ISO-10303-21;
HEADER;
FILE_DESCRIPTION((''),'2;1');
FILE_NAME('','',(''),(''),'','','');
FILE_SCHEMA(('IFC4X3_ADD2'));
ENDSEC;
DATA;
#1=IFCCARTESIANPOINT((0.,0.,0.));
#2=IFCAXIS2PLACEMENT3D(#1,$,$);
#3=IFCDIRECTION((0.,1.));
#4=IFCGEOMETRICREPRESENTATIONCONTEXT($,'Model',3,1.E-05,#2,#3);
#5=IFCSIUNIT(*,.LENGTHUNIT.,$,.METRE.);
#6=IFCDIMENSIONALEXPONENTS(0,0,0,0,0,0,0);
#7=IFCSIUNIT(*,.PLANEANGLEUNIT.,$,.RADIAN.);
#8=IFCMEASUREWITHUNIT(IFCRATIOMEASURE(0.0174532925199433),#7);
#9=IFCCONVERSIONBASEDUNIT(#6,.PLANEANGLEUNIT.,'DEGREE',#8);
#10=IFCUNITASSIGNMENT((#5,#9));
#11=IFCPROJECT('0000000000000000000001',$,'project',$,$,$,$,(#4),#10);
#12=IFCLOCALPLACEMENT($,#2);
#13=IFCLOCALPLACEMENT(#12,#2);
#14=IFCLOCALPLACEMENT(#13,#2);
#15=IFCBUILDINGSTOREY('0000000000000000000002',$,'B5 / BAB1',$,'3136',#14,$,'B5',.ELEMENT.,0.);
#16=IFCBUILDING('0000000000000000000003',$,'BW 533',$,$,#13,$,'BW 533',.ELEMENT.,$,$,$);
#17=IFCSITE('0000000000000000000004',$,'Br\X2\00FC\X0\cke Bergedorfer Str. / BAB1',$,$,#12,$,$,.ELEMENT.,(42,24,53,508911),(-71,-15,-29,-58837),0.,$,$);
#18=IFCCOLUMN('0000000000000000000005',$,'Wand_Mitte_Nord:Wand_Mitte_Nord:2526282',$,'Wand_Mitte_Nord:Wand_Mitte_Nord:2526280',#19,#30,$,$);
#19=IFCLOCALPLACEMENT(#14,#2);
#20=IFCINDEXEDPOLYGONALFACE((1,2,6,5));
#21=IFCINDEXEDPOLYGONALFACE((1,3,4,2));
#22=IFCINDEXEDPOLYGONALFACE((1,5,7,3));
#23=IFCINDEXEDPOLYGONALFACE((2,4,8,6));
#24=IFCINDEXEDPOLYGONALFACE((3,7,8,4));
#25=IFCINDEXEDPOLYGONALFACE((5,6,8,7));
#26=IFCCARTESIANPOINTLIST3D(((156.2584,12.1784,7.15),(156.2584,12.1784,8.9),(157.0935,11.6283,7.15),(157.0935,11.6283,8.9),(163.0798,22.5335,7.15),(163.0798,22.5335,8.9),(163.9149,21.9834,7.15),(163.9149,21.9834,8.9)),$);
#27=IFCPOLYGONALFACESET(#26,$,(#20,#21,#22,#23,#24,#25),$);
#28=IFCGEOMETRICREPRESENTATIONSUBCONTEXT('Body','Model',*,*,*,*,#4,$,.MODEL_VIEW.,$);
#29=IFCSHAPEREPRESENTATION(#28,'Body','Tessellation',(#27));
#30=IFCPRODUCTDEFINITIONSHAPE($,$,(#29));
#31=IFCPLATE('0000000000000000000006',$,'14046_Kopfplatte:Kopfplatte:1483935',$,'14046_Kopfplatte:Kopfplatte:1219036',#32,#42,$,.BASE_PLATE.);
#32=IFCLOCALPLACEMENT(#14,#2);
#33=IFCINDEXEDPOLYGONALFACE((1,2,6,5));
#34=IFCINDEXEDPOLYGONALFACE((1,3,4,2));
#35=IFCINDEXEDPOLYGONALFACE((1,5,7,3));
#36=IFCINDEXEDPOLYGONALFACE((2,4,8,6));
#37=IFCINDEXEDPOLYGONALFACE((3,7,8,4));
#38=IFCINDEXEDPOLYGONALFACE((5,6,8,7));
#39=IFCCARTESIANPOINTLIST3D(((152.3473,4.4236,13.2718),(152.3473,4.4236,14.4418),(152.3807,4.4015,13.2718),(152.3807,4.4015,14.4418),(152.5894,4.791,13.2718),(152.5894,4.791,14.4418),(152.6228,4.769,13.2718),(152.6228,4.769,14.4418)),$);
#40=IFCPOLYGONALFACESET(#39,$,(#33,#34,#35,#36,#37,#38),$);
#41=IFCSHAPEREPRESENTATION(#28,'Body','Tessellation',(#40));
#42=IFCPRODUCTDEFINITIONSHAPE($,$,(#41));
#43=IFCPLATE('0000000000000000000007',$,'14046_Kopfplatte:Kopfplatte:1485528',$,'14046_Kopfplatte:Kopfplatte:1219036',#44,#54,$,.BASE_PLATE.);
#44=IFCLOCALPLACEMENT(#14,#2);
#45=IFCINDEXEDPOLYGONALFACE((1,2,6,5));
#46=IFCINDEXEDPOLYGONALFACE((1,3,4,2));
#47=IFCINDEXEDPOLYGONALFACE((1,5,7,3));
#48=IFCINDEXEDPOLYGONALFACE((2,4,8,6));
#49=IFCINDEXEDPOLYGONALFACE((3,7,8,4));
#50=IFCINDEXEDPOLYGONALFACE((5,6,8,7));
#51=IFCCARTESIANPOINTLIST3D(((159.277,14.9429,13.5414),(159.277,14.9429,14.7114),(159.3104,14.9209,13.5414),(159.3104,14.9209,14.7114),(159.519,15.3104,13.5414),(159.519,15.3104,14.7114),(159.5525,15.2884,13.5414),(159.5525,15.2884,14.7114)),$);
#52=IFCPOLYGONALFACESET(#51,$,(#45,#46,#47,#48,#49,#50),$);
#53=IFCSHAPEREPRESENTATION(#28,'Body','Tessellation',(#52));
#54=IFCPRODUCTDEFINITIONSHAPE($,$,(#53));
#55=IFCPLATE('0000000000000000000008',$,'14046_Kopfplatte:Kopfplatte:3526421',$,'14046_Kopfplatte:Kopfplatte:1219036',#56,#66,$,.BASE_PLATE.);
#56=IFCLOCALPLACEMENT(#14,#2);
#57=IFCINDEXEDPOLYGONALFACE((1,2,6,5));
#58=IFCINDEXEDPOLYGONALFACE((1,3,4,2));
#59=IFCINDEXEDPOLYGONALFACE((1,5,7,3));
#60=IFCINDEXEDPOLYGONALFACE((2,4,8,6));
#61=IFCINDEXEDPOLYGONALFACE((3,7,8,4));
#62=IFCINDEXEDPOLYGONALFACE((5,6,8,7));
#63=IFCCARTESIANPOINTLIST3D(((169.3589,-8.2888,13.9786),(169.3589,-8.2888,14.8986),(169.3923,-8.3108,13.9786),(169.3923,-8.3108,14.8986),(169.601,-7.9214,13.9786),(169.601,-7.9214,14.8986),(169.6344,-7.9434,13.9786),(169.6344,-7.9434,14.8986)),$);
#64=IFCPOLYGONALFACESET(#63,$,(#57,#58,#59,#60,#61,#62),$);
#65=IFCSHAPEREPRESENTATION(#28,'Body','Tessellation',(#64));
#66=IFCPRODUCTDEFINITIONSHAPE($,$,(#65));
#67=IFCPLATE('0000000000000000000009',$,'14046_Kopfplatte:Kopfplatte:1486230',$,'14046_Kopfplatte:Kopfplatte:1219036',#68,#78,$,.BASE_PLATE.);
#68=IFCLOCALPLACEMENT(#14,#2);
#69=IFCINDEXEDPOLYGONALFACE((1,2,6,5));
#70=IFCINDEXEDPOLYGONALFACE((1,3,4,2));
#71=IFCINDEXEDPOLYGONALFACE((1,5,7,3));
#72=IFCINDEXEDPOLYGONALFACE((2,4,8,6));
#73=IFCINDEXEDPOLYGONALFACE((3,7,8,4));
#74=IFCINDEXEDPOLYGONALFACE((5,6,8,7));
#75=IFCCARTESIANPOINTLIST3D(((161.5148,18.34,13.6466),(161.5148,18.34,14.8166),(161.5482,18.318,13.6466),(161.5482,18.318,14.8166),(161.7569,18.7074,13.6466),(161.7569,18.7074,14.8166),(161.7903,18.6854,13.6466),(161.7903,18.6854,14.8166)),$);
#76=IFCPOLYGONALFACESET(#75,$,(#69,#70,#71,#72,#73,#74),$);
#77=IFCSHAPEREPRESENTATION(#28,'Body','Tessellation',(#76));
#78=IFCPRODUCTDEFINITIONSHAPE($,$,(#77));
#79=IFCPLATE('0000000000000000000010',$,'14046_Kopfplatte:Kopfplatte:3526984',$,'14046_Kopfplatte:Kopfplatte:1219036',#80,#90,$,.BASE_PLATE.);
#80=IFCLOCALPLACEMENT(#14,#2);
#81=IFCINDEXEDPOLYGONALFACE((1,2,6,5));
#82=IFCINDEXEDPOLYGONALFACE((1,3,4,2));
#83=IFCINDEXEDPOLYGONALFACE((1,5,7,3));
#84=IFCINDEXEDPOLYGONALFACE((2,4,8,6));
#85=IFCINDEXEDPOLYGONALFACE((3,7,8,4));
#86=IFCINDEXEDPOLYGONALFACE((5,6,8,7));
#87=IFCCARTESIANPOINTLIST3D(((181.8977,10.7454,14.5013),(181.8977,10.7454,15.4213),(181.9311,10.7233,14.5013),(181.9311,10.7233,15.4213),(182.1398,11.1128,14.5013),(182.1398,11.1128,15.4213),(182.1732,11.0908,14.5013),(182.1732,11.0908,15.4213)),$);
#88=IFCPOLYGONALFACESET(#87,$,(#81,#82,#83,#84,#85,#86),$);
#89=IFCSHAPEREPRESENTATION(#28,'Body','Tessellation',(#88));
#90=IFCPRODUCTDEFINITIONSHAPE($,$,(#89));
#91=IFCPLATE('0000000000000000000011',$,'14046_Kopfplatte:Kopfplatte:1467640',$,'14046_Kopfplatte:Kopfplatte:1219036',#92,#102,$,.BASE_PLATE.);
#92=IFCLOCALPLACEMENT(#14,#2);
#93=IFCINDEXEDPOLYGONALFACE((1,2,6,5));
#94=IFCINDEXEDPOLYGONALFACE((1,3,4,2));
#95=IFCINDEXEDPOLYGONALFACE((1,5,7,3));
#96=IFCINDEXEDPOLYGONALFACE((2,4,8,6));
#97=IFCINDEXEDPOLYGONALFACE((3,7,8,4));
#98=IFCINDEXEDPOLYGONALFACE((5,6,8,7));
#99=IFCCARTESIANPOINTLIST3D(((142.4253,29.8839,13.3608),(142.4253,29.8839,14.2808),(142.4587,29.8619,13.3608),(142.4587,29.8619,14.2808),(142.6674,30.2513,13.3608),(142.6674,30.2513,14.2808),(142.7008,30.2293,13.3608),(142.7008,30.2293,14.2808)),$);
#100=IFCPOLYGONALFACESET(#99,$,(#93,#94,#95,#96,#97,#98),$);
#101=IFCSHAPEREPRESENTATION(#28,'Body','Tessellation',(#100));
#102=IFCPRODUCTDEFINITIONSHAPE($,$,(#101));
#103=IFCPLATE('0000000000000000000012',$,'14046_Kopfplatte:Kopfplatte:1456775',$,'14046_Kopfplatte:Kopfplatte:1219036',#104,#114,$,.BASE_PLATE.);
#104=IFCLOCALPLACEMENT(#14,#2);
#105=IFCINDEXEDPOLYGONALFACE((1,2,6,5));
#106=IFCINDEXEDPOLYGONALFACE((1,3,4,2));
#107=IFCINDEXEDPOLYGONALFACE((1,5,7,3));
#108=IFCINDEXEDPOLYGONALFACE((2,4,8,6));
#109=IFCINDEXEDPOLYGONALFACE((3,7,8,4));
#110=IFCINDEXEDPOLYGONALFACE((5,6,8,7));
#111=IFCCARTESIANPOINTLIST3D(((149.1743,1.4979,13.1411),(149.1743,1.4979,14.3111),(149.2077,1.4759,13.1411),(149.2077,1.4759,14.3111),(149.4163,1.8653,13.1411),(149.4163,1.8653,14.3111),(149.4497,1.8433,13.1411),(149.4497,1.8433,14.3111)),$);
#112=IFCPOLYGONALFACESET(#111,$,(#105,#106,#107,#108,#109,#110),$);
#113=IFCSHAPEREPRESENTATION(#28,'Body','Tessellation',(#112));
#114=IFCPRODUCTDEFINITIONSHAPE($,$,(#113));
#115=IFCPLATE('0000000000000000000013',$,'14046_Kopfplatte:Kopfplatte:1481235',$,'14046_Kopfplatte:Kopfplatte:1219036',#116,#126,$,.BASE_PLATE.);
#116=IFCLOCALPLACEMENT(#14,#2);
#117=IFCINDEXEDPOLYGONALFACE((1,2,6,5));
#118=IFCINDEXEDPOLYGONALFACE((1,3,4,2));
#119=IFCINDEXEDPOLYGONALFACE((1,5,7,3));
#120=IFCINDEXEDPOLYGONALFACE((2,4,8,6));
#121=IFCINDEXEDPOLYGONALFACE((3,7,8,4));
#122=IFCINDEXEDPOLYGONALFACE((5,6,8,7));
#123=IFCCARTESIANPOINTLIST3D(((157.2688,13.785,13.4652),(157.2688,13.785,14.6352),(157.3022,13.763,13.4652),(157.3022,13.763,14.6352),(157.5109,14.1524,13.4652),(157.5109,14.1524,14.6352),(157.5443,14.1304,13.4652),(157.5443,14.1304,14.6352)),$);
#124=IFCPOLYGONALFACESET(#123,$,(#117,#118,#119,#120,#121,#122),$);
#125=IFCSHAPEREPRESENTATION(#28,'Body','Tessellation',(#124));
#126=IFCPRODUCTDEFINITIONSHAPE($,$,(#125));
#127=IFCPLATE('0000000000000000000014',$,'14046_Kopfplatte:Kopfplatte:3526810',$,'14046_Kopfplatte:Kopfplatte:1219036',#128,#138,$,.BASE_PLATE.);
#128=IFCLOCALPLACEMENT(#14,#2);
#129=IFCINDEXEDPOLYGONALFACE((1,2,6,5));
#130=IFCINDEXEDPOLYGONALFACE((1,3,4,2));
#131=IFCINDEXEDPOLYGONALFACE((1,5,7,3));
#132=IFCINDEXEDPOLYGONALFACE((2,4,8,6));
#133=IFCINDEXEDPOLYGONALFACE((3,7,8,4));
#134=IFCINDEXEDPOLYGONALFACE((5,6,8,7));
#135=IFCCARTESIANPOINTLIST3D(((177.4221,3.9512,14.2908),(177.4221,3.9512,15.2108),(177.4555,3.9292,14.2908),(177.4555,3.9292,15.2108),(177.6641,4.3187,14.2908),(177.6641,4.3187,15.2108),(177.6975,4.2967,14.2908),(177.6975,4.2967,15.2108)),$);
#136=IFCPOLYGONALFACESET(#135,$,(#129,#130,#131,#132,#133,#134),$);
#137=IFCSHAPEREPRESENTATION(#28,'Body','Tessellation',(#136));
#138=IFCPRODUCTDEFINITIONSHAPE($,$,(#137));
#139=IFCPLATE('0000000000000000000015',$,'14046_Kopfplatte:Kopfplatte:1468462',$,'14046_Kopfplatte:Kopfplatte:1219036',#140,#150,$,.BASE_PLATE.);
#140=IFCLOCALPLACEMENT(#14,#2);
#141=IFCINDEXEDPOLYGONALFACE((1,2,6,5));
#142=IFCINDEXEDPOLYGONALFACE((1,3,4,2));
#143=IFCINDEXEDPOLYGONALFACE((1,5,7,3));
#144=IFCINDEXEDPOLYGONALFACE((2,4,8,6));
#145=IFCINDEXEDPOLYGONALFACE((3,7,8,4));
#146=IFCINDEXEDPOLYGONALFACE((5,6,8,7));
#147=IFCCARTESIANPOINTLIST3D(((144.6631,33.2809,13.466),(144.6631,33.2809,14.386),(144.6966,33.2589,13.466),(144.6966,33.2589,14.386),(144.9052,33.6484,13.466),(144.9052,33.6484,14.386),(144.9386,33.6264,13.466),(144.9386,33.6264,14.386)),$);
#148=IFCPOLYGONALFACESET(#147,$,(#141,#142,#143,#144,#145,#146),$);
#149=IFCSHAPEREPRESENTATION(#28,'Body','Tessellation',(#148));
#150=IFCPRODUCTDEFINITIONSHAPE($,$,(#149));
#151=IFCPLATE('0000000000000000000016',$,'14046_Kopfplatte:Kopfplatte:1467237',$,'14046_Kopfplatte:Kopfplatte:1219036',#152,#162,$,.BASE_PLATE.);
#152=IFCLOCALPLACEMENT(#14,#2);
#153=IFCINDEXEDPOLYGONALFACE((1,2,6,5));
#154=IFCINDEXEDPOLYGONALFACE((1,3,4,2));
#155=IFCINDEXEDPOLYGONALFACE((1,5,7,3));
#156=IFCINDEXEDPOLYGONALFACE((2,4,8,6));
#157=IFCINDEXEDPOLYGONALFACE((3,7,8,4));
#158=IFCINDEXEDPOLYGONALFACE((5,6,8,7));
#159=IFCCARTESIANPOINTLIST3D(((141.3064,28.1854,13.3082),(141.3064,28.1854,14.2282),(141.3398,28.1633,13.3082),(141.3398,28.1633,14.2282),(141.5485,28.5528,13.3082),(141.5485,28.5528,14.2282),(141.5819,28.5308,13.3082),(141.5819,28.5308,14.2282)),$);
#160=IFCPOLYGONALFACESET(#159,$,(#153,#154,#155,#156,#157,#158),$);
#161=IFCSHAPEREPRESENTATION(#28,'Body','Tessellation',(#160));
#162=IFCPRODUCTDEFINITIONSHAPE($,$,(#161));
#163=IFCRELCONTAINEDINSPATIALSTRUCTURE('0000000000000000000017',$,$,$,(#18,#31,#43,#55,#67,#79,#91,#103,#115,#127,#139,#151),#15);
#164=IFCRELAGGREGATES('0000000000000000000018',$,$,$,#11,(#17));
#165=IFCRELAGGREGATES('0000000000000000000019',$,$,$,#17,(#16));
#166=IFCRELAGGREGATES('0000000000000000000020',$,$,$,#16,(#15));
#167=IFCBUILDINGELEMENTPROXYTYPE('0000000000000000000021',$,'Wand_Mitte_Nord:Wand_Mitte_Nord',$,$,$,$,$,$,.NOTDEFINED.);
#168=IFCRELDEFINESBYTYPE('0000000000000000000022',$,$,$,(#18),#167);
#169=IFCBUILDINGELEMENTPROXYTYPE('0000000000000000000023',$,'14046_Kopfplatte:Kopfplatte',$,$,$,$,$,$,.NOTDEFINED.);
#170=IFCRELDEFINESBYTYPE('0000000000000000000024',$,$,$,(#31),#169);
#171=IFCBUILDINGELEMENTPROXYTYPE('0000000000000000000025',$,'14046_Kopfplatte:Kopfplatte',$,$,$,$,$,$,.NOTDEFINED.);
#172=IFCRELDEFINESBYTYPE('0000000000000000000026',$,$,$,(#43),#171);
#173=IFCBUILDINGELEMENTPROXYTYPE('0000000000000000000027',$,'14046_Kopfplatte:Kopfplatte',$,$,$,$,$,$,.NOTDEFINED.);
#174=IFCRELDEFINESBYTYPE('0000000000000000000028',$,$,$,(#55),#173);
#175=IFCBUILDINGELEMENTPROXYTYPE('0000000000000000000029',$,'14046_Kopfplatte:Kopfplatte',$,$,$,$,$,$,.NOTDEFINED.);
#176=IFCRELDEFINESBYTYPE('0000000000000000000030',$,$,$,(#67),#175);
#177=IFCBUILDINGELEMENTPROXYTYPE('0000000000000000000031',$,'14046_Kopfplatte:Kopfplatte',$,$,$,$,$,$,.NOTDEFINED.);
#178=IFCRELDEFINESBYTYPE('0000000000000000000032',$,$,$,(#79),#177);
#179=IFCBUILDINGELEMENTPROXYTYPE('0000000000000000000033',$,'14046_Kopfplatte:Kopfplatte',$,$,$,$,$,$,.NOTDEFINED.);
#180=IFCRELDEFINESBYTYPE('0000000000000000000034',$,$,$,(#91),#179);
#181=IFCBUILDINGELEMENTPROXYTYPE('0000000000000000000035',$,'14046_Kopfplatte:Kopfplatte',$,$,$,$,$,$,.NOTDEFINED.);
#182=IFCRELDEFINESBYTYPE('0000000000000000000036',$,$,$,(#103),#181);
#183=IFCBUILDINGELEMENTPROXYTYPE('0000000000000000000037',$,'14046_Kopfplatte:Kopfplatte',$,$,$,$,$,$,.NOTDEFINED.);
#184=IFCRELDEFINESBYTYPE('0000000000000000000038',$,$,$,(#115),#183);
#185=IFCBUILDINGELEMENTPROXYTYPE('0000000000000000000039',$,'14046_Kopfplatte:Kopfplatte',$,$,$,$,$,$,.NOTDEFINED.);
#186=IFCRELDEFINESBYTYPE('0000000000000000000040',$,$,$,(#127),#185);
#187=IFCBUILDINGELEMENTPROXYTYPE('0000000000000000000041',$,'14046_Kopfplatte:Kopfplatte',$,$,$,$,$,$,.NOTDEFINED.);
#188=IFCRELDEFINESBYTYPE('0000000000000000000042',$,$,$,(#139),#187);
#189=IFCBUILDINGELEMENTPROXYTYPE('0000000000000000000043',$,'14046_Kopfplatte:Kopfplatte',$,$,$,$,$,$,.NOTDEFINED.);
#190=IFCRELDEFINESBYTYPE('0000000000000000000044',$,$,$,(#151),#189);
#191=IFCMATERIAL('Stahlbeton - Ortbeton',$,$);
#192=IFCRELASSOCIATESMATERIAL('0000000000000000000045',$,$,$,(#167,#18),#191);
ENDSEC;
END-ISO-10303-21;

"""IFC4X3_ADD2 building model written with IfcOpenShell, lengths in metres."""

from ifc_helpers import new_model, entity, si_unit, converted_unit, direction, frame, frame_2d, origin, origin_2d_with_axis, place, context, subcontext, project, spatial, rectangle, extrude, source, transform, mapped, material, type_object, type_shapes, element, save


model = new_model("IFC4X3_ADD2")

# Units and contexts
model_context = context("Model", 3, precision=1e-05, world=origin(), true_north=direction((0.0, 1.0)))
body_context = subcontext(model_context, "Body", "Model", "MODEL_VIEW")
ifc_project = project(units=[si_unit("LENGTHUNIT", "METRE"), converted_unit("PLANEANGLEUNIT", "DEGREE", entity("IfcRatioMeasure", 0.0174532925199433), si_unit("PLANEANGLEUNIT", "RADIAN"), dimensions=[0, 0, 0, 0, 0, 0, 0])], contexts=[model_context])

# Site, building, storey
site_placement = place(None, origin())
site = spatial("IfcSite", under=ifc_project, at=site_placement, Name="Brücke Bergedorfer Str. / BAB1", CompositionType="ELEMENT", RefLatitude=(42, 24, 53, 508911), RefLongitude=(-71, -15, -29, -58837), RefElevation=0.0)
building_placement = place(site_placement, origin())
building = spatial("IfcBuilding", under=site, at=building_placement, Name="BW 533", LongName="BW 533", CompositionType="ELEMENT")
storey_placement = place(building_placement, origin())
storey = spatial("IfcBuildingStorey", under=building, at=storey_placement, Name="B5 / BAB1", ObjectType="3136", LongName="B5", CompositionType="ELEMENT", Elevation=0.0)

# Shared definitions
ifc_material_1 = material(Name="Stahlbeton - Ortbeton")

# Column
building_element_proxy_type_1 = type_object("IfcBuildingElementProxyType", Name="Wand_Mitte_Nord:Wand_Mitte_Nord", PredefinedType="NOTDEFINED", material=ifc_material_1)
shared_shape_1 = source(origin(), body_context, "Body", "SweptSolid", [
    extrude(rectangle(XDim=12.4, YDim=1.0, at=frame_2d((0.0, 0.0), x_axis=(1.0, 0.0))), frame((160.0866, 17.0809, 7.15), z_axis=(0.0, 0.0, 1.0), x_axis=(0.550116, 0.835088, 0.0)), (0.0, 0.0, 1.0), 1.75),
])
type_shapes(building_element_proxy_type_1, [shared_shape_1])
column_placement = place(storey_placement, origin())
element("IfcColumn", 1, at=column_placement, inside=storey, type_object=building_element_proxy_type_1, material=ifc_material_1, Name="Wand_Mitte_Nord:Wand_Mitte_Nord:2526282", ObjectType="Wand_Mitte_Nord:Wand_Mitte_Nord:2526280", context=body_context, shape_type="MappedRepresentation", body=[
    mapped(shared_shape_1, transform((0.0, 0.0, 0.0), scale=1.0)),
])

# Plates
building_element_proxy_type_2 = type_object("IfcBuildingElementProxyType", Name="14046_Kopfplatte:Kopfplatte", PredefinedType="NOTDEFINED")
shared_shape_2 = source(origin(), body_context, "Body", "SweptSolid", [
    extrude(rectangle(XDim=0.04, YDim=0.44, at=frame_2d((0.0, 0.0), x_axis=(1.0, 0.0))), frame((152.4851, 4.5963, 13.2718), z_axis=(0.0, 0.0, 1.0), x_axis=(-0.835088, 0.550116, 0.0)), (0.0, 0.0, 1.0), 1.17),
])
type_shapes(building_element_proxy_type_2, [shared_shape_2])
plate_1_placement = place(storey_placement, origin())
element("IfcPlate", 2, at=plate_1_placement, inside=storey, type_object=building_element_proxy_type_2, Name="14046_Kopfplatte:Kopfplatte:1483935", ObjectType="14046_Kopfplatte:Kopfplatte:1219036", PredefinedType="BASE_PLATE", context=body_context, shape_type="MappedRepresentation", body=[
    mapped(shared_shape_2, transform((0.0, 0.0, 0.0), scale=1.0)),
])
building_element_proxy_type_3 = type_object("IfcBuildingElementProxyType", Name="14046_Kopfplatte:Kopfplatte", PredefinedType="NOTDEFINED")
shared_shape_3 = source(origin(), body_context, "Body", "SweptSolid", [
    extrude(rectangle(XDim=0.04, YDim=0.44, at=frame_2d((0.0, 0.0), x_axis=(1.0, 0.0))), frame((159.4147, 15.1157, 13.5414), z_axis=(0.0, 0.0, 1.0), x_axis=(-0.835088, 0.550116, 0.0)), (0.0, 0.0, 1.0), 1.17),
])
type_shapes(building_element_proxy_type_3, [shared_shape_3])
plate_2_placement = place(storey_placement, origin())
element("IfcPlate", 3, at=plate_2_placement, inside=storey, type_object=building_element_proxy_type_3, Name="14046_Kopfplatte:Kopfplatte:1485528", ObjectType="14046_Kopfplatte:Kopfplatte:1219036", PredefinedType="BASE_PLATE", context=body_context, shape_type="MappedRepresentation", body=[
    mapped(shared_shape_3, transform((0.0, 0.0, 0.0), scale=1.0)),
])
building_element_proxy_type_4 = type_object("IfcBuildingElementProxyType", Name="14046_Kopfplatte:Kopfplatte", PredefinedType="NOTDEFINED")
shared_shape_4 = source(origin(), body_context, "Body", "SweptSolid", [
    extrude(rectangle(XDim=0.04, YDim=0.44, at=frame_2d((0.0, 0.0), x_axis=(1.0, 0.0))), frame((169.4966, -8.1161, 13.9786), z_axis=(0.0, 0.0, 1.0), x_axis=(0.835088, -0.550116, 0.0)), (0.0, 0.0, 1.0), 0.92),
])
type_shapes(building_element_proxy_type_4, [shared_shape_4])
plate_3_placement = place(storey_placement, origin())
element("IfcPlate", 4, at=plate_3_placement, inside=storey, type_object=building_element_proxy_type_4, Name="14046_Kopfplatte:Kopfplatte:3526421", ObjectType="14046_Kopfplatte:Kopfplatte:1219036", PredefinedType="BASE_PLATE", context=body_context, shape_type="MappedRepresentation", body=[
    mapped(shared_shape_4, transform((0.0, 0.0, 0.0), scale=1.0)),
])
building_element_proxy_type_5 = type_object("IfcBuildingElementProxyType", Name="14046_Kopfplatte:Kopfplatte", PredefinedType="NOTDEFINED")
shared_shape_5 = source(origin(), body_context, "Body", "SweptSolid", [
    extrude(rectangle(XDim=0.04, YDim=0.44, at=frame_2d((0.0, 0.0), x_axis=(1.0, 0.0))), frame((161.6525, 18.5127, 13.6466), z_axis=(0.0, 0.0, 1.0), x_axis=(-0.835088, 0.550116, 0.0)), (0.0, 0.0, 1.0), 1.17),
])
type_shapes(building_element_proxy_type_5, [shared_shape_5])
plate_4_placement = place(storey_placement, origin())
element("IfcPlate", 5, at=plate_4_placement, inside=storey, type_object=building_element_proxy_type_5, Name="14046_Kopfplatte:Kopfplatte:1486230", ObjectType="14046_Kopfplatte:Kopfplatte:1219036", PredefinedType="BASE_PLATE", context=body_context, shape_type="MappedRepresentation", body=[
    mapped(shared_shape_5, transform((0.0, 0.0, 0.0), scale=1.0)),
])
building_element_proxy_type_6 = type_object("IfcBuildingElementProxyType", Name="14046_Kopfplatte:Kopfplatte", PredefinedType="NOTDEFINED")
shared_shape_6 = source(origin(), body_context, "Body", "SweptSolid", [
    extrude(rectangle(XDim=0.04, YDim=0.44, at=frame_2d((0.0, 0.0), x_axis=(1.0, 0.0))), frame((182.0354, 10.9181, 14.5013), z_axis=(0.0, 0.0, 1.0), x_axis=(0.835088, -0.550116, 0.0)), (0.0, 0.0, 1.0), 0.92),
])
type_shapes(building_element_proxy_type_6, [shared_shape_6])
plate_5_placement = place(storey_placement, origin())
element("IfcPlate", 6, at=plate_5_placement, inside=storey, type_object=building_element_proxy_type_6, Name="14046_Kopfplatte:Kopfplatte:3526984", ObjectType="14046_Kopfplatte:Kopfplatte:1219036", PredefinedType="BASE_PLATE", context=body_context, shape_type="MappedRepresentation", body=[
    mapped(shared_shape_6, transform((0.0, 0.0, 0.0), scale=1.0)),
])
building_element_proxy_type_7 = type_object("IfcBuildingElementProxyType", Name="14046_Kopfplatte:Kopfplatte", PredefinedType="NOTDEFINED")
shared_shape_7 = source(origin(), body_context, "Body", "SweptSolid", [
    extrude(rectangle(XDim=0.04, YDim=0.44, at=frame_2d((0.0, 0.0), x_axis=(1.0, 0.0))), frame((142.5631, 30.0566, 13.3608), z_axis=(0.0, 0.0, 1.0), x_axis=(-0.835088, 0.550116, 0.0)), (0.0, 0.0, 1.0), 0.92),
])
type_shapes(building_element_proxy_type_7, [shared_shape_7])
plate_6_placement = place(storey_placement, origin())
element("IfcPlate", 7, at=plate_6_placement, inside=storey, type_object=building_element_proxy_type_7, Name="14046_Kopfplatte:Kopfplatte:1467640", ObjectType="14046_Kopfplatte:Kopfplatte:1219036", PredefinedType="BASE_PLATE", context=body_context, shape_type="MappedRepresentation", body=[
    mapped(shared_shape_7, transform((0.0, 0.0, 0.0), scale=1.0)),
])
building_element_proxy_type_8 = type_object("IfcBuildingElementProxyType", Name="14046_Kopfplatte:Kopfplatte", PredefinedType="NOTDEFINED")
shared_shape_8 = source(origin(), body_context, "Body", "SweptSolid", [
    extrude(rectangle(XDim=0.04, YDim=0.44, at=origin_2d_with_axis()), frame((149.312, 1.6706, 13.1411), z_axis=(0.0, 0.0, 1.0), x_axis=(0.835088, -0.550116, 0.0)), (0.0, 0.0, 1.0), 1.17),
])
type_shapes(building_element_proxy_type_8, [shared_shape_8])
plate_7_placement = place(storey_placement, origin())
element("IfcPlate", 8, at=plate_7_placement, inside=storey, type_object=building_element_proxy_type_8, Name="14046_Kopfplatte:Kopfplatte:1456775", ObjectType="14046_Kopfplatte:Kopfplatte:1219036", PredefinedType="BASE_PLATE", context=body_context, shape_type="MappedRepresentation", body=[
    mapped(shared_shape_8, transform((0.0, 0.0, 0.0), scale=1.0)),
])
building_element_proxy_type_9 = type_object("IfcBuildingElementProxyType", Name="14046_Kopfplatte:Kopfplatte", PredefinedType="NOTDEFINED")
shared_shape_9 = source(origin(), body_context, "Body", "SweptSolid", [
    extrude(rectangle(XDim=0.04, YDim=0.44, at=frame_2d((0.0, 0.0), x_axis=(1.0, 0.0))), frame((157.4065, 13.9577, 13.4652), z_axis=(0.0, 0.0, 1.0), x_axis=(0.835088, -0.550116, 0.0)), (0.0, 0.0, 1.0), 1.17),
])
type_shapes(building_element_proxy_type_9, [shared_shape_9])
plate_8_placement = place(storey_placement, origin())
element("IfcPlate", 9, at=plate_8_placement, inside=storey, type_object=building_element_proxy_type_9, Name="14046_Kopfplatte:Kopfplatte:1481235", ObjectType="14046_Kopfplatte:Kopfplatte:1219036", PredefinedType="BASE_PLATE", context=body_context, shape_type="MappedRepresentation", body=[
    mapped(shared_shape_9, transform((0.0, 0.0, 0.0), scale=1.0)),
])
building_element_proxy_type_10 = type_object("IfcBuildingElementProxyType", Name="14046_Kopfplatte:Kopfplatte", PredefinedType="NOTDEFINED")
shared_shape_10 = source(origin(), body_context, "Body", "SweptSolid", [
    extrude(rectangle(XDim=0.04, YDim=0.44, at=frame_2d((0.0, 0.0), x_axis=(1.0, 0.0))), frame((177.5598, 4.124, 14.2908), z_axis=(0.0, 0.0, 1.0), x_axis=(0.835088, -0.550116, 0.0)), (0.0, 0.0, 1.0), 0.92),
])
type_shapes(building_element_proxy_type_10, [shared_shape_10])
plate_9_placement = place(storey_placement, origin())
element("IfcPlate", 10, at=plate_9_placement, inside=storey, type_object=building_element_proxy_type_10, Name="14046_Kopfplatte:Kopfplatte:3526810", ObjectType="14046_Kopfplatte:Kopfplatte:1219036", PredefinedType="BASE_PLATE", context=body_context, shape_type="MappedRepresentation", body=[
    mapped(shared_shape_10, transform((0.0, 0.0, 0.0), scale=1.0)),
])
building_element_proxy_type_11 = type_object("IfcBuildingElementProxyType", Name="14046_Kopfplatte:Kopfplatte", PredefinedType="NOTDEFINED")
shared_shape_11 = source(origin(), body_context, "Body", "SweptSolid", [
    extrude(rectangle(XDim=0.04, YDim=0.44, at=frame_2d((0.0, 0.0), x_axis=(1.0, 0.0))), frame((144.8009, 33.4537, 13.466), z_axis=(0.0, 0.0, 1.0), x_axis=(-0.835088, 0.550116, 0.0)), (0.0, 0.0, 1.0), 0.92),
])
type_shapes(building_element_proxy_type_11, [shared_shape_11])
plate_10_placement = place(storey_placement, origin())
element("IfcPlate", 11, at=plate_10_placement, inside=storey, type_object=building_element_proxy_type_11, Name="14046_Kopfplatte:Kopfplatte:1468462", ObjectType="14046_Kopfplatte:Kopfplatte:1219036", PredefinedType="BASE_PLATE", context=body_context, shape_type="MappedRepresentation", body=[
    mapped(shared_shape_11, transform((0.0, 0.0, 0.0), scale=1.0)),
])
building_element_proxy_type_12 = type_object("IfcBuildingElementProxyType", Name="14046_Kopfplatte:Kopfplatte", PredefinedType="NOTDEFINED")
shared_shape_12 = source(origin(), body_context, "Body", "SweptSolid", [
    extrude(rectangle(XDim=0.04, YDim=0.44, at=frame_2d((0.0, 0.0), x_axis=(1.0, 0.0))), frame((141.4441, 28.3581, 13.3082), z_axis=(0.0, 0.0, 1.0), x_axis=(-0.835088, 0.550116, 0.0)), (0.0, 0.0, 1.0), 0.92),
])
type_shapes(building_element_proxy_type_12, [shared_shape_12])
plate_11_placement = place(storey_placement, origin())
element("IfcPlate", 12, at=plate_11_placement, inside=storey, type_object=building_element_proxy_type_12, Name="14046_Kopfplatte:Kopfplatte:1467237", ObjectType="14046_Kopfplatte:Kopfplatte:1219036", PredefinedType="BASE_PLATE", context=body_context, shape_type="MappedRepresentation", body=[
    mapped(shared_shape_12, transform((0.0, 0.0, 0.0), scale=1.0)),
])

save(model, "model.ifc")
